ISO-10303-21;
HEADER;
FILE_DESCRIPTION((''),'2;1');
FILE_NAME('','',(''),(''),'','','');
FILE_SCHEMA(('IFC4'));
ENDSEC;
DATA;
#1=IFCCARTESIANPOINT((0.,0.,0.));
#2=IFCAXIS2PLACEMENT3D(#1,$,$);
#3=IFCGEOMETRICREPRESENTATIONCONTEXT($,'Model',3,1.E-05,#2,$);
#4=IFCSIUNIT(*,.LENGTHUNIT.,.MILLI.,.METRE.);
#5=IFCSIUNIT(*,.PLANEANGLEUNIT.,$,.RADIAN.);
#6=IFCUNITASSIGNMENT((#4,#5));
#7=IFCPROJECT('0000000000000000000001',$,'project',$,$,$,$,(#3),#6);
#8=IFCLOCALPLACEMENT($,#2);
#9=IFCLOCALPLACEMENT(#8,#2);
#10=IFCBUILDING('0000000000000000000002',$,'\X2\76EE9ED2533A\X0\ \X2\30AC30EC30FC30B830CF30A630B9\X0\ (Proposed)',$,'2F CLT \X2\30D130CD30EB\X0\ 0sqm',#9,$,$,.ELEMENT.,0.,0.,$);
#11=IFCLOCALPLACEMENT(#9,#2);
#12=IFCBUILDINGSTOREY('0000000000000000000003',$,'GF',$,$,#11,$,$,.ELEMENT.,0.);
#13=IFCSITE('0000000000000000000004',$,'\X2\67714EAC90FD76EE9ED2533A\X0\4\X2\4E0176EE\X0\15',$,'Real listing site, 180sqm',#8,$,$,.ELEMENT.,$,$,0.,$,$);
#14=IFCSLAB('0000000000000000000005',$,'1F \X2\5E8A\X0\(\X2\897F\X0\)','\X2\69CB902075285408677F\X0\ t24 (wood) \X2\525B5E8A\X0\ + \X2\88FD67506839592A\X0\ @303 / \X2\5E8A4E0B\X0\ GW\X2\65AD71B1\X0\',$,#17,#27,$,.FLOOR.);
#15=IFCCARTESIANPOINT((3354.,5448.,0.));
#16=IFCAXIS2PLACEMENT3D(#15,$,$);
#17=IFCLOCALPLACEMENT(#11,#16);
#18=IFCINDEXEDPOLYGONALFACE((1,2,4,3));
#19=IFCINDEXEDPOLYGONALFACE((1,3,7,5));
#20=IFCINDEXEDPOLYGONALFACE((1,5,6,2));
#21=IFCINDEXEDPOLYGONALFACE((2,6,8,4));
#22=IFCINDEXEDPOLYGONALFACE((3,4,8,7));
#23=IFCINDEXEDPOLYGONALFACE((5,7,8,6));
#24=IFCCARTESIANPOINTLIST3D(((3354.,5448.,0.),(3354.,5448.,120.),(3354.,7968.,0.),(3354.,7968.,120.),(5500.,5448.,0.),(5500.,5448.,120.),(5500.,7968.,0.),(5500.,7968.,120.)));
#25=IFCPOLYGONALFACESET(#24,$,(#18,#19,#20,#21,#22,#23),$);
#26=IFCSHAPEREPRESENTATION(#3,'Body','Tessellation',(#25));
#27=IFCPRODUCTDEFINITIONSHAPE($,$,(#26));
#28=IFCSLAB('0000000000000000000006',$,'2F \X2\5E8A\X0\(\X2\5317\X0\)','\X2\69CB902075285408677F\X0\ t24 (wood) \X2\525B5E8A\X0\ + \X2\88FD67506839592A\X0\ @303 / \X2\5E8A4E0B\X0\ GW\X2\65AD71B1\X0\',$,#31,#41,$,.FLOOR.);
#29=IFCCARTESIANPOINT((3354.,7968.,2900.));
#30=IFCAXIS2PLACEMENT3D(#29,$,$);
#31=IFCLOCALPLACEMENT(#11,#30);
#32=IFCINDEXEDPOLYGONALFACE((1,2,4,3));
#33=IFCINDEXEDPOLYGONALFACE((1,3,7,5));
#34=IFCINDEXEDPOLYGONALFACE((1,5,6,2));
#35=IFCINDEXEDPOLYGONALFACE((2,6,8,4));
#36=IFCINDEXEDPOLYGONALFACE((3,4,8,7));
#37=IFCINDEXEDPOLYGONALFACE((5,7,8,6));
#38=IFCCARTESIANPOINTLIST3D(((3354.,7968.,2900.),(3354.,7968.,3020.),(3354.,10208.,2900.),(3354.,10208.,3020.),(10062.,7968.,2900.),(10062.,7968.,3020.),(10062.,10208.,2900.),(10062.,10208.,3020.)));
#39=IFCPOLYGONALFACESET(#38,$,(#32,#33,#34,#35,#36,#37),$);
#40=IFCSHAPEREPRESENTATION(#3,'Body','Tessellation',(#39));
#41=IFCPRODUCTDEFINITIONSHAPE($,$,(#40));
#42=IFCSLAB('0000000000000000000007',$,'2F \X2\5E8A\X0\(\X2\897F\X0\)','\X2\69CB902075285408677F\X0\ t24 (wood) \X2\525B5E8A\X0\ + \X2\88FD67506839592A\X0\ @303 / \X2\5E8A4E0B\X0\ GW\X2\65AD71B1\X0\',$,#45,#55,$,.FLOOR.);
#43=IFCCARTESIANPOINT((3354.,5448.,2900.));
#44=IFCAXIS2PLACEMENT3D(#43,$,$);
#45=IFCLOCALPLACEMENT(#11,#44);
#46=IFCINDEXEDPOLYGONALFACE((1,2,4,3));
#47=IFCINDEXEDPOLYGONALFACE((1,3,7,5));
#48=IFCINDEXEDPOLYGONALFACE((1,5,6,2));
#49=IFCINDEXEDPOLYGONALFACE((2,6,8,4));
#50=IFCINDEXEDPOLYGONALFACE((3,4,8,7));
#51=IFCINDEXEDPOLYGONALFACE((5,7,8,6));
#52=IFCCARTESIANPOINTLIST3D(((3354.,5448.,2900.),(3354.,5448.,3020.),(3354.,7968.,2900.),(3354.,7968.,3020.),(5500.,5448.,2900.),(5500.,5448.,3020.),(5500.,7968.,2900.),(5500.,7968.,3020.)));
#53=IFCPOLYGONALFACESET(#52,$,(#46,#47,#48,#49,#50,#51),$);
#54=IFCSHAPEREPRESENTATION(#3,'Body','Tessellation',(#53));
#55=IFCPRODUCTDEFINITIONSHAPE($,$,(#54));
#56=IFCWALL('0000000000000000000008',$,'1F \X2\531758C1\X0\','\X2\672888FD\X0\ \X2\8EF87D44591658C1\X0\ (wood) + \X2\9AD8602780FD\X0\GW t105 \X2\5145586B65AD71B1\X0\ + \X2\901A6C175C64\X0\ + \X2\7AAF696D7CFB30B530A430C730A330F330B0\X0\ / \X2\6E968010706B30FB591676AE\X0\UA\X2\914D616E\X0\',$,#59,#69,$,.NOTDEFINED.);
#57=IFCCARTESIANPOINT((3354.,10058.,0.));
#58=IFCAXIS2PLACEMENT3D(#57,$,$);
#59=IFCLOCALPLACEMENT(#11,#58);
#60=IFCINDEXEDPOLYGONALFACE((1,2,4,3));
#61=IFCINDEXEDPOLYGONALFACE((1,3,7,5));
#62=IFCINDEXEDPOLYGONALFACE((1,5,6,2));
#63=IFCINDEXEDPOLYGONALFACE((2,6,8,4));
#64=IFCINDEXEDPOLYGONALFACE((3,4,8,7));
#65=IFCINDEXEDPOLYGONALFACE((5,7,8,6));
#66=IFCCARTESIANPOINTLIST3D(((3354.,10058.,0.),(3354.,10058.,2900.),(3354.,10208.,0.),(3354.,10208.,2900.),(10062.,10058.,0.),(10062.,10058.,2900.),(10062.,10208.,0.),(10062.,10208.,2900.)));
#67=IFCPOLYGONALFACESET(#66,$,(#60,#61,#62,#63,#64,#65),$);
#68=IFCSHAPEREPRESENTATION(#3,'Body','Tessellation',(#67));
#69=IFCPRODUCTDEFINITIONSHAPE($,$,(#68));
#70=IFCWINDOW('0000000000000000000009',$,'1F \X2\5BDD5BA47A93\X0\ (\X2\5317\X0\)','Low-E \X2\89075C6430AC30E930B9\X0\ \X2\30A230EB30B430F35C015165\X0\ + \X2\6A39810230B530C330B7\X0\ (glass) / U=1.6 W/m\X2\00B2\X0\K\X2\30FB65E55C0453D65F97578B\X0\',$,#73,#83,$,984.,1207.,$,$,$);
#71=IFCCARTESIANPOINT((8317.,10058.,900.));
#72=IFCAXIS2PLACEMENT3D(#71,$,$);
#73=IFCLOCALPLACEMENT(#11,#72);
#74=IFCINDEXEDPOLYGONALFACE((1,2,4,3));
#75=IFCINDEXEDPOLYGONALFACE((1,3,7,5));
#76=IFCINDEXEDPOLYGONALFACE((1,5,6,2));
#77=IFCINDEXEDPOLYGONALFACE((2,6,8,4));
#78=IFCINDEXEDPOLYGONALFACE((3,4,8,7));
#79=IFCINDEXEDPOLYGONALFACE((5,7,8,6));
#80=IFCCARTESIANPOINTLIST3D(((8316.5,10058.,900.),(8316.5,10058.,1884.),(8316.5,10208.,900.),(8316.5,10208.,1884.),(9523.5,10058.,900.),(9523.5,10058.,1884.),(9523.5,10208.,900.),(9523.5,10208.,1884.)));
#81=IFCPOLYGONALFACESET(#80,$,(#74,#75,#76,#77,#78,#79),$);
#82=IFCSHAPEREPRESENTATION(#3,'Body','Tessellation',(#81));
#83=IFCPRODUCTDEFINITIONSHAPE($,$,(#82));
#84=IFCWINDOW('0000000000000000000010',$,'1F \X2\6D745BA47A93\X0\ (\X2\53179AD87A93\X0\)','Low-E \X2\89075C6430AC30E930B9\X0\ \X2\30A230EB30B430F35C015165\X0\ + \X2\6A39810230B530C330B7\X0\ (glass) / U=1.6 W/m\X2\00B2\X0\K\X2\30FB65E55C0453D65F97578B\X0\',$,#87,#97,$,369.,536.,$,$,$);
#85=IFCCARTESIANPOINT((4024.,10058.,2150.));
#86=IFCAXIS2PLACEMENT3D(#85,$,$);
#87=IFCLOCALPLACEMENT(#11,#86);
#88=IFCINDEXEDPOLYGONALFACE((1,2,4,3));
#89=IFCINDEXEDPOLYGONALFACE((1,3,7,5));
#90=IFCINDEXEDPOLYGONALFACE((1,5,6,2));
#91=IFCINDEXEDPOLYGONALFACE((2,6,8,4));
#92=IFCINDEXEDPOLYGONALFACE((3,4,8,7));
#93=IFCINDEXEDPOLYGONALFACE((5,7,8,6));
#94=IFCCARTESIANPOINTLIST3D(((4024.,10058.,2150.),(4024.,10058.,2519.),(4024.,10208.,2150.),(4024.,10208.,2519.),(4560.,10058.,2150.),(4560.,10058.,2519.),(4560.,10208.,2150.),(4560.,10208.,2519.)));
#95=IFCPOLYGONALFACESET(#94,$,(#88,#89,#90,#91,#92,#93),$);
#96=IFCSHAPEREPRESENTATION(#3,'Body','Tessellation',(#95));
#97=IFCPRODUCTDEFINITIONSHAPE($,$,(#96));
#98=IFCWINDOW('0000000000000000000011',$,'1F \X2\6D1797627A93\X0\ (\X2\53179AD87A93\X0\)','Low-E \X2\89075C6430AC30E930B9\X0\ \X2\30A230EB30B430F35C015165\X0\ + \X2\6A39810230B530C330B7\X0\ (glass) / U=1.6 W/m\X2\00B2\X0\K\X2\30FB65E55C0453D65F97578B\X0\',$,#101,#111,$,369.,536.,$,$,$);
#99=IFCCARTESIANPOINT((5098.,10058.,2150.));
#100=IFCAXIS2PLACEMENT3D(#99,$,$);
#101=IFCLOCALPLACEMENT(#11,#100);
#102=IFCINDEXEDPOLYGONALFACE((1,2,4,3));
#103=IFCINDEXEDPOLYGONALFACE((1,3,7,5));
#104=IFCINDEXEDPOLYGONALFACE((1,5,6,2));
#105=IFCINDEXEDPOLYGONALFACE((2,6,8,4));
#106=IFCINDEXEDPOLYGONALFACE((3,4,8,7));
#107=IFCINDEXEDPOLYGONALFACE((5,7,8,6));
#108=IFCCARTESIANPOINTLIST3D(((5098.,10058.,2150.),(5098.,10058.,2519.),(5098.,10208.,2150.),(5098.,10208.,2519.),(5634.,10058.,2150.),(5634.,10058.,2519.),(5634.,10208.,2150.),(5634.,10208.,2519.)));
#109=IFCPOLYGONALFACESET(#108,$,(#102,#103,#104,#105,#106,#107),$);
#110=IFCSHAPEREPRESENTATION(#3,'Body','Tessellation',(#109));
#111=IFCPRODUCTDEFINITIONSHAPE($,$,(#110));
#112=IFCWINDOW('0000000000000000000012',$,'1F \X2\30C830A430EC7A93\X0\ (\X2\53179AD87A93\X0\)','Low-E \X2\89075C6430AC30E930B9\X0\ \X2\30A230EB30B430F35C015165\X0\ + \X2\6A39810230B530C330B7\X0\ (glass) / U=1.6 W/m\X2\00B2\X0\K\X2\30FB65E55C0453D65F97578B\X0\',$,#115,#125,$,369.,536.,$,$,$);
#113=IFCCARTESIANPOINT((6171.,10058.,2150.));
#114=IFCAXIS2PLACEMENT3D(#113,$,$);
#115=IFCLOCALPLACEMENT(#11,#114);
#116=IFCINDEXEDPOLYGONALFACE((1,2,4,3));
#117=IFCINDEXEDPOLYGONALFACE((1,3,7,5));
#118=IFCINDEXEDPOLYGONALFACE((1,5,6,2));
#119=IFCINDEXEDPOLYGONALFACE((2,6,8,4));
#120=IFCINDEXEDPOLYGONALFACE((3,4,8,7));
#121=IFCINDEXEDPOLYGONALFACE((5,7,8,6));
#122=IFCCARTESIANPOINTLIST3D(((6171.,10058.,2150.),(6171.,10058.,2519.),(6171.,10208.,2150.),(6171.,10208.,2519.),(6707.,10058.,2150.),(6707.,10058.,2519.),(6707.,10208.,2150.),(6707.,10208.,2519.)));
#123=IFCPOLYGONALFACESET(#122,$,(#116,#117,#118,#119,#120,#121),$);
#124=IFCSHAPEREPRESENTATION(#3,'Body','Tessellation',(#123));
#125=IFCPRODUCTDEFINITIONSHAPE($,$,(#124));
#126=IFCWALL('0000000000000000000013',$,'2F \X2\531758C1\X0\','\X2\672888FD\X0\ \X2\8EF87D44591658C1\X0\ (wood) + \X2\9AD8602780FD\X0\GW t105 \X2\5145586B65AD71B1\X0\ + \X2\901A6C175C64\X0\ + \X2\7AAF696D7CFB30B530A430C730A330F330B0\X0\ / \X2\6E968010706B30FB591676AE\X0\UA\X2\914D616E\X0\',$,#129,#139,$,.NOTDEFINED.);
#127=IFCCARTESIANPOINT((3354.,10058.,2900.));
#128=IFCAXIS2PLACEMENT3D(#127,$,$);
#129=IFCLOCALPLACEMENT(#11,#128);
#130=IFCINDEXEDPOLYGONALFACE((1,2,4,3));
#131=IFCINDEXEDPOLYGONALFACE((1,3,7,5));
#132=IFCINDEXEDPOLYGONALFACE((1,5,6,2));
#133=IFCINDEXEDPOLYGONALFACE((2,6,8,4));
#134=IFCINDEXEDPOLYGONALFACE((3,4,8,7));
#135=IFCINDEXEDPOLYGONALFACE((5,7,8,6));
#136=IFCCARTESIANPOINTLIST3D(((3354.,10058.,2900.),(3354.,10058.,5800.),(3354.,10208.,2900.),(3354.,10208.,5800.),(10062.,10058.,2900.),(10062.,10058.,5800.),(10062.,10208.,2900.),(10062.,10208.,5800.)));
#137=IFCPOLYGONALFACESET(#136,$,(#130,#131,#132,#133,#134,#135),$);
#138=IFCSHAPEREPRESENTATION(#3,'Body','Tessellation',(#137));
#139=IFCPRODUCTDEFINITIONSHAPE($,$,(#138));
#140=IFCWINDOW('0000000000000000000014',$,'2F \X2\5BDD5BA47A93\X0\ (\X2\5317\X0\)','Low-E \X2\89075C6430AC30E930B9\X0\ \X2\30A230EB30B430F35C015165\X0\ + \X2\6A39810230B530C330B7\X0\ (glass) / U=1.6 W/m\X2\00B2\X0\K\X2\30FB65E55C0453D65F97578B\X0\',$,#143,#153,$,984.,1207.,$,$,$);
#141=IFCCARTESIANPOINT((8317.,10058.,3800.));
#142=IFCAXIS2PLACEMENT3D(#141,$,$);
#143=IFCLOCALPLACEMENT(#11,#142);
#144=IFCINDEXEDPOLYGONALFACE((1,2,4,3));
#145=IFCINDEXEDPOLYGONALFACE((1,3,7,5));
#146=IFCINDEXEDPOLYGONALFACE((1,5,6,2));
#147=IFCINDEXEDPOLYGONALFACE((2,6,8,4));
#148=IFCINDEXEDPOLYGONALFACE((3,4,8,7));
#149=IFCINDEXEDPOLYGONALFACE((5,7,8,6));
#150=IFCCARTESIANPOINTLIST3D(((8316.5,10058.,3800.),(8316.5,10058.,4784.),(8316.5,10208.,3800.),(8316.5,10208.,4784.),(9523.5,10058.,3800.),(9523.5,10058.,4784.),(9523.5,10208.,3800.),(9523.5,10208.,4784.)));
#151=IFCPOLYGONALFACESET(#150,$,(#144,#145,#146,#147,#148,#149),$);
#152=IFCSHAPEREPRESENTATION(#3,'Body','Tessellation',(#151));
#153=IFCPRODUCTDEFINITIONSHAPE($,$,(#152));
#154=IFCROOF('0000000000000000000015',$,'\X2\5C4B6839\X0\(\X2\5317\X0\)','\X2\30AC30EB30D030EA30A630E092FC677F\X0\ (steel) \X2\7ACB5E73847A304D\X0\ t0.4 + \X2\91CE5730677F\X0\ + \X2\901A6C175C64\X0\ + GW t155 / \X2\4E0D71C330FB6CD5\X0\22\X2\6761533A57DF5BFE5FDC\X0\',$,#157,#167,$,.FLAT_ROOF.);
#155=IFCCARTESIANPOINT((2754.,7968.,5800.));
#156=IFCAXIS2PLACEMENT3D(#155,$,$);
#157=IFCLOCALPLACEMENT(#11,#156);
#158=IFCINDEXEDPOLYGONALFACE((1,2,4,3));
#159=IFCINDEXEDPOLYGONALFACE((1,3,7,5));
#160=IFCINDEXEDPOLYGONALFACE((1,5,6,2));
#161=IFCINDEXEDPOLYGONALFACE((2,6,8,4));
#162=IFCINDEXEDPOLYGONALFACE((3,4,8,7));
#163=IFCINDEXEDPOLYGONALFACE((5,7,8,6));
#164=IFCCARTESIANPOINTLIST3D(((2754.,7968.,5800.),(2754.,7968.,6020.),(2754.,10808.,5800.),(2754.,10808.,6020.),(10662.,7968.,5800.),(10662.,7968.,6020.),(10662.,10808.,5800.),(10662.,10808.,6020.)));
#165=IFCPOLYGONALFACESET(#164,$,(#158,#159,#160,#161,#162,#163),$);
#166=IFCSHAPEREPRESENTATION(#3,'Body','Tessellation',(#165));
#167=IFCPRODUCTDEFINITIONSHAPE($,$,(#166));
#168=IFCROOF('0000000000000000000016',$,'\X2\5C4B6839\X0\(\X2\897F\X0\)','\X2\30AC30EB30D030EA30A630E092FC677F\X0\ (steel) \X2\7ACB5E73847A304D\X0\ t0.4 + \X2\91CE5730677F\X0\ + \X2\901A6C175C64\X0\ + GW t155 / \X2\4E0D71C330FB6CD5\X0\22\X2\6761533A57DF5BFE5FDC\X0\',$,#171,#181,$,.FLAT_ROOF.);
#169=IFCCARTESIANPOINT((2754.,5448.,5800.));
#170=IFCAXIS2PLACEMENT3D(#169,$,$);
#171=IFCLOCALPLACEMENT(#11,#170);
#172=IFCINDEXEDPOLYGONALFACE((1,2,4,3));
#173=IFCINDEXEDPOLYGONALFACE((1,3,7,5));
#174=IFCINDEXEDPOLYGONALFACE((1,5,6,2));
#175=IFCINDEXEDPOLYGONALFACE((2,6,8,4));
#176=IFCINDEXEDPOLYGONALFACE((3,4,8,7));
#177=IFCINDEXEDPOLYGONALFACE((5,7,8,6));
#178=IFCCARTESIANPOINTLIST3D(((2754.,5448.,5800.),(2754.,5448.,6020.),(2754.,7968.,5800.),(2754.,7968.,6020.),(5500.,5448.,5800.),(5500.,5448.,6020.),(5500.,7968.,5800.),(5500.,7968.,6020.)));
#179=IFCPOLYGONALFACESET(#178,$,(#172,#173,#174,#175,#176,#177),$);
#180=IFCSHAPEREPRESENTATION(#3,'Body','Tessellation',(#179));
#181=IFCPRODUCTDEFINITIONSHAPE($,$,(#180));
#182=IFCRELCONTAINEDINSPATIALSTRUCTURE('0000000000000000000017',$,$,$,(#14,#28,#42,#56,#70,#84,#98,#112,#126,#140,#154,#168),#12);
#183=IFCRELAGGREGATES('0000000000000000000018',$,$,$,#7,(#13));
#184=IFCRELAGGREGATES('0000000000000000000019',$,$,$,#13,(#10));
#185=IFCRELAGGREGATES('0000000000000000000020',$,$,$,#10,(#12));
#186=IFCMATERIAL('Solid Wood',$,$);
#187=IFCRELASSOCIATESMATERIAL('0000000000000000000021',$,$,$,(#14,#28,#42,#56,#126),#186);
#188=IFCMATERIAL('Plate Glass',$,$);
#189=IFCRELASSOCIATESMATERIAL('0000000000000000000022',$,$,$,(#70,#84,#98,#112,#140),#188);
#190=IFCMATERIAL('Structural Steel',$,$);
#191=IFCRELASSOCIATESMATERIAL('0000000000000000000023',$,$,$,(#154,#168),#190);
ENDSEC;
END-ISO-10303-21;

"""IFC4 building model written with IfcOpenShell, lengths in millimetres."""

from ifc_helpers import new_model, si_unit, frame, frame_2d, origin, place, context, project, spatial, rectangle, extrude, material, element, fill, save


model = new_model("IFC4")

# Units and contexts
model_context = context("Model", 3, precision=1e-05, world=origin())
ifc_project = project(units=[si_unit("LENGTHUNIT", "METRE", prefix="MILLI"), si_unit("PLANEANGLEUNIT", "RADIAN")], contexts=[model_context])

# Site, building, storey
site_placement = place(None, origin())
site = spatial("IfcSite", under=ifc_project, at=site_placement, Name="東京都目黒区4丁目15", ObjectType="Real listing site, 180sqm", CompositionType="ELEMENT", RefElevation=0.0)
building_placement = place(site_placement, origin())
building = spatial("IfcBuilding", under=site, at=building_placement, Name="目黒区 ガレージハウス (Proposed)", ObjectType="2F CLT パネル 0sqm", CompositionType="ELEMENT", ElevationOfRefHeight=0.0, ElevationOfTerrain=0.0)
storey_placement = place(building_placement, origin())
storey = spatial("IfcBuildingStorey", under=building, at=storey_placement, Name="GF", CompositionType="ELEMENT", Elevation=0.0)

# Slabs
ifc_material_1 = material(Name="Solid Wood")
slab_1_placement = place(storey_placement, frame((3354.0, 5448.0, 0.0)))
element("IfcSlab", 1, at=slab_1_placement, inside=storey, material=ifc_material_1, Name="1F 床(西)", Description="構造用合板 t24 (wood) 剛床 + 製材根太 @303 / 床下 GW断熱", PredefinedType="FLOOR", context=model_context, shape_type="SweptSolid", body=[
    extrude(rectangle(XDim=2146.0, YDim=2520.0, at=frame_2d((1073.0, 1260.0))), frame((3354.0, 5448.0, 0.0)), (0.0, 0.0, 1.0), 120.0),
])
slab_2_placement = place(storey_placement, frame((3354.0, 7968.0, 2900.0)))
element("IfcSlab", 2, at=slab_2_placement, inside=storey, material=ifc_material_1, Name="2F 床(北)", Description="構造用合板 t24 (wood) 剛床 + 製材根太 @303 / 床下 GW断熱", PredefinedType="FLOOR", context=model_context, shape_type="SweptSolid", body=[
    extrude(rectangle(XDim=6708.0, YDim=2240.0, at=frame_2d((3354.0, 1120.0))), frame((3354.0, 7968.0, 2900.0)), (0.0, 0.0, 1.0), 120.0),
])
slab_3_placement = place(storey_placement, frame((3354.0, 5448.0, 2900.0)))
element("IfcSlab", 3, at=slab_3_placement, inside=storey, material=ifc_material_1, Name="2F 床(西)", Description="構造用合板 t24 (wood) 剛床 + 製材根太 @303 / 床下 GW断熱", PredefinedType="FLOOR", context=model_context, shape_type="SweptSolid", body=[
    extrude(rectangle(XDim=2146.0, YDim=2520.0, at=frame_2d((1073.0, 1260.0))), frame((3354.0, 5448.0, 2900.0)), (0.0, 0.0, 1.0), 120.0),
])

# Wall, openings, windows
wall_1_placement = place(storey_placement, frame((3354.0, 10058.0, 0.0)))
wall_1 = element("IfcWall", 4, at=wall_1_placement, inside=storey, material=ifc_material_1, Name="1F 北壁", Description="木製 軸組外壁 (wood) + 高性能GW t105 充填断熱 + 通気層 + 窯業系サイディング / 準耐火・外皮UA配慮", PredefinedType="NOTDEFINED", context=model_context, shape_type="SweptSolid", body=[
    extrude(rectangle(XDim=6708.0, YDim=150.0, at=frame_2d((3354.0, 75.0))), frame((3354.0, 10058.0, 0.0)), (0.0, 0.0, 1.0), 2900.0),
])
opening_1_placement = place(storey_placement, frame((8317.0, 10058.0, 900.0)))
opening_1 = element("IfcOpeningElement", 5, at=opening_1_placement, cuts=wall_1, PredefinedType="NOTDEFINED", context=model_context, shape_type="SweptSolid", body=[
    extrude(rectangle(XDim=1207.0, YDim=150.0, at=frame_2d((603.0, 75.0))), frame((8317.0, 10058.0, 900.0)), (0.0, 0.0, 1.0), 984.0),
])
opening_2_placement = place(storey_placement, frame((4024.0, 10058.0, 2150.0)))
opening_2 = element("IfcOpeningElement", 6, at=opening_2_placement, cuts=wall_1, PredefinedType="NOTDEFINED", context=model_context, shape_type="SweptSolid", body=[
    extrude(rectangle(XDim=536.0, YDim=150.0, at=frame_2d((268.0, 75.0))), frame((4024.0, 10058.0, 2150.0)), (0.0, 0.0, 1.0), 369.0),
])
opening_3_placement = place(storey_placement, frame((5098.0, 10058.0, 2150.0)))
opening_3 = element("IfcOpeningElement", 7, at=opening_3_placement, cuts=wall_1, PredefinedType="NOTDEFINED", context=model_context, shape_type="SweptSolid", body=[
    extrude(rectangle(XDim=536.0, YDim=150.0, at=frame_2d((268.0, 75.0))), frame((5098.0, 10058.0, 2150.0)), (0.0, 0.0, 1.0), 369.0),
])
opening_4_placement = place(storey_placement, frame((6171.0, 10058.0, 2150.0)))
opening_4 = element("IfcOpeningElement", 8, at=opening_4_placement, cuts=wall_1, PredefinedType="NOTDEFINED", context=model_context, shape_type="SweptSolid", body=[
    extrude(rectangle(XDim=536.0, YDim=150.0, at=frame_2d((268.0, 75.0))), frame((6171.0, 10058.0, 2150.0)), (0.0, 0.0, 1.0), 369.0),
])
ifc_material_2 = material(Name="Plate Glass")
window_1_placement = place(storey_placement, frame((8317.0, 10058.0, 900.0)))
window_1 = element("IfcWindow", 9, at=window_1_placement, inside=storey, material=ifc_material_2, Name="1F 寝室窓 (北)", Description="Low-E 複層ガラス アルゴン封入 + 樹脂サッシ (glass) / U=1.6 W/m²K・日射取得型", OverallHeight=984.0, OverallWidth=1207.0, context=model_context, shape_type="SweptSolid", body=[
    extrude(rectangle(XDim=1207.0, YDim=150.0, at=frame_2d((603.0, 75.0))), frame((8317.0, 10058.0, 900.0)), (0.0, 0.0, 1.0), 984.0),
])
fill(opening_1, window_1)
window_2_placement = place(storey_placement, frame((4024.0, 10058.0, 2150.0)))
window_2 = element("IfcWindow", 10, at=window_2_placement, inside=storey, material=ifc_material_2, Name="1F 浴室窓 (北高窓)", Description="Low-E 複層ガラス アルゴン封入 + 樹脂サッシ (glass) / U=1.6 W/m²K・日射取得型", OverallHeight=369.0, OverallWidth=536.0, context=model_context, shape_type="SweptSolid", body=[
    extrude(rectangle(XDim=536.0, YDim=150.0, at=frame_2d((268.0, 75.0))), frame((4024.0, 10058.0, 2150.0)), (0.0, 0.0, 1.0), 369.0),
])
fill(opening_2, window_2)
window_3_placement = place(storey_placement, frame((5098.0, 10058.0, 2150.0)))
window_3 = element("IfcWindow", 11, at=window_3_placement, inside=storey, material=ifc_material_2, Name="1F 洗面窓 (北高窓)", Description="Low-E 複層ガラス アルゴン封入 + 樹脂サッシ (glass) / U=1.6 W/m²K・日射取得型", OverallHeight=369.0, OverallWidth=536.0, context=model_context, shape_type="SweptSolid", body=[
    extrude(rectangle(XDim=536.0, YDim=150.0, at=frame_2d((268.0, 75.0))), frame((5098.0, 10058.0, 2150.0)), (0.0, 0.0, 1.0), 369.0),
])
fill(opening_3, window_3)
window_4_placement = place(storey_placement, frame((6171.0, 10058.0, 2150.0)))
window_4 = element("IfcWindow", 12, at=window_4_placement, inside=storey, material=ifc_material_2, Name="1F トイレ窓 (北高窓)", Description="Low-E 複層ガラス アルゴン封入 + 樹脂サッシ (glass) / U=1.6 W/m²K・日射取得型", OverallHeight=369.0, OverallWidth=536.0, context=model_context, shape_type="SweptSolid", body=[
    extrude(rectangle(XDim=536.0, YDim=150.0, at=frame_2d((268.0, 75.0))), frame((6171.0, 10058.0, 2150.0)), (0.0, 0.0, 1.0), 369.0),
])
fill(opening_4, window_4)

# Wall, opening, window
wall_2_placement = place(storey_placement, frame((3354.0, 10058.0, 2900.0)))
wall_2 = element("IfcWall", 13, at=wall_2_placement, inside=storey, material=ifc_material_1, Name="2F 北壁", Description="木製 軸組外壁 (wood) + 高性能GW t105 充填断熱 + 通気層 + 窯業系サイディング / 準耐火・外皮UA配慮", PredefinedType="NOTDEFINED", context=model_context, shape_type="SweptSolid", body=[
    extrude(rectangle(XDim=6708.0, YDim=150.0, at=frame_2d((3354.0, 75.0))), frame((3354.0, 10058.0, 2900.0)), (0.0, 0.0, 1.0), 2900.0),
])
opening_5_placement = place(storey_placement, frame((8317.0, 10058.0, 3800.0)))
opening_5 = element("IfcOpeningElement", 14, at=opening_5_placement, cuts=wall_2, PredefinedType="NOTDEFINED", context=model_context, shape_type="SweptSolid", body=[
    extrude(rectangle(XDim=1207.0, YDim=150.0, at=frame_2d((603.0, 75.0))), frame((8317.0, 10058.0, 3800.0)), (0.0, 0.0, 1.0), 984.0),
])
window_5_placement = place(storey_placement, frame((8317.0, 10058.0, 3800.0)))
window_5 = element("IfcWindow", 15, at=window_5_placement, inside=storey, material=ifc_material_2, Name="2F 寝室窓 (北)", Description="Low-E 複層ガラス アルゴン封入 + 樹脂サッシ (glass) / U=1.6 W/m²K・日射取得型", OverallHeight=984.0, OverallWidth=1207.0, context=model_context, shape_type="SweptSolid", body=[
    extrude(rectangle(XDim=1207.0, YDim=150.0, at=frame_2d((603.0, 75.0))), frame((8317.0, 10058.0, 3800.0)), (0.0, 0.0, 1.0), 984.0),
])
fill(opening_5, window_5)

# Roofs
ifc_material_3 = material(Name="Structural Steel")
for number, where, name in (
    (16, (2754.0, 7968.0, 5800.0), "屋根(北)"),
):
    element("IfcRoof", number, at=place(storey_placement, frame(where)), inside=storey, material=ifc_material_3, Name=name, Description="ガルバリウム鋼板 (steel) 立平葺き t0.4 + 野地板 + 通気層 + GW t155 / 不燃・法22条区域対応", PredefinedType="FLAT_ROOF", context=model_context, shape_type="SweptSolid", body=[
        extrude(rectangle(XDim=7908.0, YDim=2840.0, at=frame_2d((3954.0, 1420.0))), frame((2754.0, 7968.0, 5800.0)), (0.0, 0.0, 1.0), 220.0),
    ])
roof_placement = place(storey_placement, frame((2754.0, 5448.0, 5800.0)))
element("IfcRoof", 17, at=roof_placement, inside=storey, material=ifc_material_3, Name="屋根(西)", Description="ガルバリウム鋼板 (steel) 立平葺き t0.4 + 野地板 + 通気層 + GW t155 / 不燃・法22条区域対応", PredefinedType="FLAT_ROOF", context=model_context, shape_type="SweptSolid", body=[
    extrude(rectangle(XDim=2746.0, YDim=2520.0, at=frame_2d((1373.0, 1260.0))), frame((2754.0, 5448.0, 5800.0)), (0.0, 0.0, 1.0), 220.0),
])

save(model, "model.ifc")
